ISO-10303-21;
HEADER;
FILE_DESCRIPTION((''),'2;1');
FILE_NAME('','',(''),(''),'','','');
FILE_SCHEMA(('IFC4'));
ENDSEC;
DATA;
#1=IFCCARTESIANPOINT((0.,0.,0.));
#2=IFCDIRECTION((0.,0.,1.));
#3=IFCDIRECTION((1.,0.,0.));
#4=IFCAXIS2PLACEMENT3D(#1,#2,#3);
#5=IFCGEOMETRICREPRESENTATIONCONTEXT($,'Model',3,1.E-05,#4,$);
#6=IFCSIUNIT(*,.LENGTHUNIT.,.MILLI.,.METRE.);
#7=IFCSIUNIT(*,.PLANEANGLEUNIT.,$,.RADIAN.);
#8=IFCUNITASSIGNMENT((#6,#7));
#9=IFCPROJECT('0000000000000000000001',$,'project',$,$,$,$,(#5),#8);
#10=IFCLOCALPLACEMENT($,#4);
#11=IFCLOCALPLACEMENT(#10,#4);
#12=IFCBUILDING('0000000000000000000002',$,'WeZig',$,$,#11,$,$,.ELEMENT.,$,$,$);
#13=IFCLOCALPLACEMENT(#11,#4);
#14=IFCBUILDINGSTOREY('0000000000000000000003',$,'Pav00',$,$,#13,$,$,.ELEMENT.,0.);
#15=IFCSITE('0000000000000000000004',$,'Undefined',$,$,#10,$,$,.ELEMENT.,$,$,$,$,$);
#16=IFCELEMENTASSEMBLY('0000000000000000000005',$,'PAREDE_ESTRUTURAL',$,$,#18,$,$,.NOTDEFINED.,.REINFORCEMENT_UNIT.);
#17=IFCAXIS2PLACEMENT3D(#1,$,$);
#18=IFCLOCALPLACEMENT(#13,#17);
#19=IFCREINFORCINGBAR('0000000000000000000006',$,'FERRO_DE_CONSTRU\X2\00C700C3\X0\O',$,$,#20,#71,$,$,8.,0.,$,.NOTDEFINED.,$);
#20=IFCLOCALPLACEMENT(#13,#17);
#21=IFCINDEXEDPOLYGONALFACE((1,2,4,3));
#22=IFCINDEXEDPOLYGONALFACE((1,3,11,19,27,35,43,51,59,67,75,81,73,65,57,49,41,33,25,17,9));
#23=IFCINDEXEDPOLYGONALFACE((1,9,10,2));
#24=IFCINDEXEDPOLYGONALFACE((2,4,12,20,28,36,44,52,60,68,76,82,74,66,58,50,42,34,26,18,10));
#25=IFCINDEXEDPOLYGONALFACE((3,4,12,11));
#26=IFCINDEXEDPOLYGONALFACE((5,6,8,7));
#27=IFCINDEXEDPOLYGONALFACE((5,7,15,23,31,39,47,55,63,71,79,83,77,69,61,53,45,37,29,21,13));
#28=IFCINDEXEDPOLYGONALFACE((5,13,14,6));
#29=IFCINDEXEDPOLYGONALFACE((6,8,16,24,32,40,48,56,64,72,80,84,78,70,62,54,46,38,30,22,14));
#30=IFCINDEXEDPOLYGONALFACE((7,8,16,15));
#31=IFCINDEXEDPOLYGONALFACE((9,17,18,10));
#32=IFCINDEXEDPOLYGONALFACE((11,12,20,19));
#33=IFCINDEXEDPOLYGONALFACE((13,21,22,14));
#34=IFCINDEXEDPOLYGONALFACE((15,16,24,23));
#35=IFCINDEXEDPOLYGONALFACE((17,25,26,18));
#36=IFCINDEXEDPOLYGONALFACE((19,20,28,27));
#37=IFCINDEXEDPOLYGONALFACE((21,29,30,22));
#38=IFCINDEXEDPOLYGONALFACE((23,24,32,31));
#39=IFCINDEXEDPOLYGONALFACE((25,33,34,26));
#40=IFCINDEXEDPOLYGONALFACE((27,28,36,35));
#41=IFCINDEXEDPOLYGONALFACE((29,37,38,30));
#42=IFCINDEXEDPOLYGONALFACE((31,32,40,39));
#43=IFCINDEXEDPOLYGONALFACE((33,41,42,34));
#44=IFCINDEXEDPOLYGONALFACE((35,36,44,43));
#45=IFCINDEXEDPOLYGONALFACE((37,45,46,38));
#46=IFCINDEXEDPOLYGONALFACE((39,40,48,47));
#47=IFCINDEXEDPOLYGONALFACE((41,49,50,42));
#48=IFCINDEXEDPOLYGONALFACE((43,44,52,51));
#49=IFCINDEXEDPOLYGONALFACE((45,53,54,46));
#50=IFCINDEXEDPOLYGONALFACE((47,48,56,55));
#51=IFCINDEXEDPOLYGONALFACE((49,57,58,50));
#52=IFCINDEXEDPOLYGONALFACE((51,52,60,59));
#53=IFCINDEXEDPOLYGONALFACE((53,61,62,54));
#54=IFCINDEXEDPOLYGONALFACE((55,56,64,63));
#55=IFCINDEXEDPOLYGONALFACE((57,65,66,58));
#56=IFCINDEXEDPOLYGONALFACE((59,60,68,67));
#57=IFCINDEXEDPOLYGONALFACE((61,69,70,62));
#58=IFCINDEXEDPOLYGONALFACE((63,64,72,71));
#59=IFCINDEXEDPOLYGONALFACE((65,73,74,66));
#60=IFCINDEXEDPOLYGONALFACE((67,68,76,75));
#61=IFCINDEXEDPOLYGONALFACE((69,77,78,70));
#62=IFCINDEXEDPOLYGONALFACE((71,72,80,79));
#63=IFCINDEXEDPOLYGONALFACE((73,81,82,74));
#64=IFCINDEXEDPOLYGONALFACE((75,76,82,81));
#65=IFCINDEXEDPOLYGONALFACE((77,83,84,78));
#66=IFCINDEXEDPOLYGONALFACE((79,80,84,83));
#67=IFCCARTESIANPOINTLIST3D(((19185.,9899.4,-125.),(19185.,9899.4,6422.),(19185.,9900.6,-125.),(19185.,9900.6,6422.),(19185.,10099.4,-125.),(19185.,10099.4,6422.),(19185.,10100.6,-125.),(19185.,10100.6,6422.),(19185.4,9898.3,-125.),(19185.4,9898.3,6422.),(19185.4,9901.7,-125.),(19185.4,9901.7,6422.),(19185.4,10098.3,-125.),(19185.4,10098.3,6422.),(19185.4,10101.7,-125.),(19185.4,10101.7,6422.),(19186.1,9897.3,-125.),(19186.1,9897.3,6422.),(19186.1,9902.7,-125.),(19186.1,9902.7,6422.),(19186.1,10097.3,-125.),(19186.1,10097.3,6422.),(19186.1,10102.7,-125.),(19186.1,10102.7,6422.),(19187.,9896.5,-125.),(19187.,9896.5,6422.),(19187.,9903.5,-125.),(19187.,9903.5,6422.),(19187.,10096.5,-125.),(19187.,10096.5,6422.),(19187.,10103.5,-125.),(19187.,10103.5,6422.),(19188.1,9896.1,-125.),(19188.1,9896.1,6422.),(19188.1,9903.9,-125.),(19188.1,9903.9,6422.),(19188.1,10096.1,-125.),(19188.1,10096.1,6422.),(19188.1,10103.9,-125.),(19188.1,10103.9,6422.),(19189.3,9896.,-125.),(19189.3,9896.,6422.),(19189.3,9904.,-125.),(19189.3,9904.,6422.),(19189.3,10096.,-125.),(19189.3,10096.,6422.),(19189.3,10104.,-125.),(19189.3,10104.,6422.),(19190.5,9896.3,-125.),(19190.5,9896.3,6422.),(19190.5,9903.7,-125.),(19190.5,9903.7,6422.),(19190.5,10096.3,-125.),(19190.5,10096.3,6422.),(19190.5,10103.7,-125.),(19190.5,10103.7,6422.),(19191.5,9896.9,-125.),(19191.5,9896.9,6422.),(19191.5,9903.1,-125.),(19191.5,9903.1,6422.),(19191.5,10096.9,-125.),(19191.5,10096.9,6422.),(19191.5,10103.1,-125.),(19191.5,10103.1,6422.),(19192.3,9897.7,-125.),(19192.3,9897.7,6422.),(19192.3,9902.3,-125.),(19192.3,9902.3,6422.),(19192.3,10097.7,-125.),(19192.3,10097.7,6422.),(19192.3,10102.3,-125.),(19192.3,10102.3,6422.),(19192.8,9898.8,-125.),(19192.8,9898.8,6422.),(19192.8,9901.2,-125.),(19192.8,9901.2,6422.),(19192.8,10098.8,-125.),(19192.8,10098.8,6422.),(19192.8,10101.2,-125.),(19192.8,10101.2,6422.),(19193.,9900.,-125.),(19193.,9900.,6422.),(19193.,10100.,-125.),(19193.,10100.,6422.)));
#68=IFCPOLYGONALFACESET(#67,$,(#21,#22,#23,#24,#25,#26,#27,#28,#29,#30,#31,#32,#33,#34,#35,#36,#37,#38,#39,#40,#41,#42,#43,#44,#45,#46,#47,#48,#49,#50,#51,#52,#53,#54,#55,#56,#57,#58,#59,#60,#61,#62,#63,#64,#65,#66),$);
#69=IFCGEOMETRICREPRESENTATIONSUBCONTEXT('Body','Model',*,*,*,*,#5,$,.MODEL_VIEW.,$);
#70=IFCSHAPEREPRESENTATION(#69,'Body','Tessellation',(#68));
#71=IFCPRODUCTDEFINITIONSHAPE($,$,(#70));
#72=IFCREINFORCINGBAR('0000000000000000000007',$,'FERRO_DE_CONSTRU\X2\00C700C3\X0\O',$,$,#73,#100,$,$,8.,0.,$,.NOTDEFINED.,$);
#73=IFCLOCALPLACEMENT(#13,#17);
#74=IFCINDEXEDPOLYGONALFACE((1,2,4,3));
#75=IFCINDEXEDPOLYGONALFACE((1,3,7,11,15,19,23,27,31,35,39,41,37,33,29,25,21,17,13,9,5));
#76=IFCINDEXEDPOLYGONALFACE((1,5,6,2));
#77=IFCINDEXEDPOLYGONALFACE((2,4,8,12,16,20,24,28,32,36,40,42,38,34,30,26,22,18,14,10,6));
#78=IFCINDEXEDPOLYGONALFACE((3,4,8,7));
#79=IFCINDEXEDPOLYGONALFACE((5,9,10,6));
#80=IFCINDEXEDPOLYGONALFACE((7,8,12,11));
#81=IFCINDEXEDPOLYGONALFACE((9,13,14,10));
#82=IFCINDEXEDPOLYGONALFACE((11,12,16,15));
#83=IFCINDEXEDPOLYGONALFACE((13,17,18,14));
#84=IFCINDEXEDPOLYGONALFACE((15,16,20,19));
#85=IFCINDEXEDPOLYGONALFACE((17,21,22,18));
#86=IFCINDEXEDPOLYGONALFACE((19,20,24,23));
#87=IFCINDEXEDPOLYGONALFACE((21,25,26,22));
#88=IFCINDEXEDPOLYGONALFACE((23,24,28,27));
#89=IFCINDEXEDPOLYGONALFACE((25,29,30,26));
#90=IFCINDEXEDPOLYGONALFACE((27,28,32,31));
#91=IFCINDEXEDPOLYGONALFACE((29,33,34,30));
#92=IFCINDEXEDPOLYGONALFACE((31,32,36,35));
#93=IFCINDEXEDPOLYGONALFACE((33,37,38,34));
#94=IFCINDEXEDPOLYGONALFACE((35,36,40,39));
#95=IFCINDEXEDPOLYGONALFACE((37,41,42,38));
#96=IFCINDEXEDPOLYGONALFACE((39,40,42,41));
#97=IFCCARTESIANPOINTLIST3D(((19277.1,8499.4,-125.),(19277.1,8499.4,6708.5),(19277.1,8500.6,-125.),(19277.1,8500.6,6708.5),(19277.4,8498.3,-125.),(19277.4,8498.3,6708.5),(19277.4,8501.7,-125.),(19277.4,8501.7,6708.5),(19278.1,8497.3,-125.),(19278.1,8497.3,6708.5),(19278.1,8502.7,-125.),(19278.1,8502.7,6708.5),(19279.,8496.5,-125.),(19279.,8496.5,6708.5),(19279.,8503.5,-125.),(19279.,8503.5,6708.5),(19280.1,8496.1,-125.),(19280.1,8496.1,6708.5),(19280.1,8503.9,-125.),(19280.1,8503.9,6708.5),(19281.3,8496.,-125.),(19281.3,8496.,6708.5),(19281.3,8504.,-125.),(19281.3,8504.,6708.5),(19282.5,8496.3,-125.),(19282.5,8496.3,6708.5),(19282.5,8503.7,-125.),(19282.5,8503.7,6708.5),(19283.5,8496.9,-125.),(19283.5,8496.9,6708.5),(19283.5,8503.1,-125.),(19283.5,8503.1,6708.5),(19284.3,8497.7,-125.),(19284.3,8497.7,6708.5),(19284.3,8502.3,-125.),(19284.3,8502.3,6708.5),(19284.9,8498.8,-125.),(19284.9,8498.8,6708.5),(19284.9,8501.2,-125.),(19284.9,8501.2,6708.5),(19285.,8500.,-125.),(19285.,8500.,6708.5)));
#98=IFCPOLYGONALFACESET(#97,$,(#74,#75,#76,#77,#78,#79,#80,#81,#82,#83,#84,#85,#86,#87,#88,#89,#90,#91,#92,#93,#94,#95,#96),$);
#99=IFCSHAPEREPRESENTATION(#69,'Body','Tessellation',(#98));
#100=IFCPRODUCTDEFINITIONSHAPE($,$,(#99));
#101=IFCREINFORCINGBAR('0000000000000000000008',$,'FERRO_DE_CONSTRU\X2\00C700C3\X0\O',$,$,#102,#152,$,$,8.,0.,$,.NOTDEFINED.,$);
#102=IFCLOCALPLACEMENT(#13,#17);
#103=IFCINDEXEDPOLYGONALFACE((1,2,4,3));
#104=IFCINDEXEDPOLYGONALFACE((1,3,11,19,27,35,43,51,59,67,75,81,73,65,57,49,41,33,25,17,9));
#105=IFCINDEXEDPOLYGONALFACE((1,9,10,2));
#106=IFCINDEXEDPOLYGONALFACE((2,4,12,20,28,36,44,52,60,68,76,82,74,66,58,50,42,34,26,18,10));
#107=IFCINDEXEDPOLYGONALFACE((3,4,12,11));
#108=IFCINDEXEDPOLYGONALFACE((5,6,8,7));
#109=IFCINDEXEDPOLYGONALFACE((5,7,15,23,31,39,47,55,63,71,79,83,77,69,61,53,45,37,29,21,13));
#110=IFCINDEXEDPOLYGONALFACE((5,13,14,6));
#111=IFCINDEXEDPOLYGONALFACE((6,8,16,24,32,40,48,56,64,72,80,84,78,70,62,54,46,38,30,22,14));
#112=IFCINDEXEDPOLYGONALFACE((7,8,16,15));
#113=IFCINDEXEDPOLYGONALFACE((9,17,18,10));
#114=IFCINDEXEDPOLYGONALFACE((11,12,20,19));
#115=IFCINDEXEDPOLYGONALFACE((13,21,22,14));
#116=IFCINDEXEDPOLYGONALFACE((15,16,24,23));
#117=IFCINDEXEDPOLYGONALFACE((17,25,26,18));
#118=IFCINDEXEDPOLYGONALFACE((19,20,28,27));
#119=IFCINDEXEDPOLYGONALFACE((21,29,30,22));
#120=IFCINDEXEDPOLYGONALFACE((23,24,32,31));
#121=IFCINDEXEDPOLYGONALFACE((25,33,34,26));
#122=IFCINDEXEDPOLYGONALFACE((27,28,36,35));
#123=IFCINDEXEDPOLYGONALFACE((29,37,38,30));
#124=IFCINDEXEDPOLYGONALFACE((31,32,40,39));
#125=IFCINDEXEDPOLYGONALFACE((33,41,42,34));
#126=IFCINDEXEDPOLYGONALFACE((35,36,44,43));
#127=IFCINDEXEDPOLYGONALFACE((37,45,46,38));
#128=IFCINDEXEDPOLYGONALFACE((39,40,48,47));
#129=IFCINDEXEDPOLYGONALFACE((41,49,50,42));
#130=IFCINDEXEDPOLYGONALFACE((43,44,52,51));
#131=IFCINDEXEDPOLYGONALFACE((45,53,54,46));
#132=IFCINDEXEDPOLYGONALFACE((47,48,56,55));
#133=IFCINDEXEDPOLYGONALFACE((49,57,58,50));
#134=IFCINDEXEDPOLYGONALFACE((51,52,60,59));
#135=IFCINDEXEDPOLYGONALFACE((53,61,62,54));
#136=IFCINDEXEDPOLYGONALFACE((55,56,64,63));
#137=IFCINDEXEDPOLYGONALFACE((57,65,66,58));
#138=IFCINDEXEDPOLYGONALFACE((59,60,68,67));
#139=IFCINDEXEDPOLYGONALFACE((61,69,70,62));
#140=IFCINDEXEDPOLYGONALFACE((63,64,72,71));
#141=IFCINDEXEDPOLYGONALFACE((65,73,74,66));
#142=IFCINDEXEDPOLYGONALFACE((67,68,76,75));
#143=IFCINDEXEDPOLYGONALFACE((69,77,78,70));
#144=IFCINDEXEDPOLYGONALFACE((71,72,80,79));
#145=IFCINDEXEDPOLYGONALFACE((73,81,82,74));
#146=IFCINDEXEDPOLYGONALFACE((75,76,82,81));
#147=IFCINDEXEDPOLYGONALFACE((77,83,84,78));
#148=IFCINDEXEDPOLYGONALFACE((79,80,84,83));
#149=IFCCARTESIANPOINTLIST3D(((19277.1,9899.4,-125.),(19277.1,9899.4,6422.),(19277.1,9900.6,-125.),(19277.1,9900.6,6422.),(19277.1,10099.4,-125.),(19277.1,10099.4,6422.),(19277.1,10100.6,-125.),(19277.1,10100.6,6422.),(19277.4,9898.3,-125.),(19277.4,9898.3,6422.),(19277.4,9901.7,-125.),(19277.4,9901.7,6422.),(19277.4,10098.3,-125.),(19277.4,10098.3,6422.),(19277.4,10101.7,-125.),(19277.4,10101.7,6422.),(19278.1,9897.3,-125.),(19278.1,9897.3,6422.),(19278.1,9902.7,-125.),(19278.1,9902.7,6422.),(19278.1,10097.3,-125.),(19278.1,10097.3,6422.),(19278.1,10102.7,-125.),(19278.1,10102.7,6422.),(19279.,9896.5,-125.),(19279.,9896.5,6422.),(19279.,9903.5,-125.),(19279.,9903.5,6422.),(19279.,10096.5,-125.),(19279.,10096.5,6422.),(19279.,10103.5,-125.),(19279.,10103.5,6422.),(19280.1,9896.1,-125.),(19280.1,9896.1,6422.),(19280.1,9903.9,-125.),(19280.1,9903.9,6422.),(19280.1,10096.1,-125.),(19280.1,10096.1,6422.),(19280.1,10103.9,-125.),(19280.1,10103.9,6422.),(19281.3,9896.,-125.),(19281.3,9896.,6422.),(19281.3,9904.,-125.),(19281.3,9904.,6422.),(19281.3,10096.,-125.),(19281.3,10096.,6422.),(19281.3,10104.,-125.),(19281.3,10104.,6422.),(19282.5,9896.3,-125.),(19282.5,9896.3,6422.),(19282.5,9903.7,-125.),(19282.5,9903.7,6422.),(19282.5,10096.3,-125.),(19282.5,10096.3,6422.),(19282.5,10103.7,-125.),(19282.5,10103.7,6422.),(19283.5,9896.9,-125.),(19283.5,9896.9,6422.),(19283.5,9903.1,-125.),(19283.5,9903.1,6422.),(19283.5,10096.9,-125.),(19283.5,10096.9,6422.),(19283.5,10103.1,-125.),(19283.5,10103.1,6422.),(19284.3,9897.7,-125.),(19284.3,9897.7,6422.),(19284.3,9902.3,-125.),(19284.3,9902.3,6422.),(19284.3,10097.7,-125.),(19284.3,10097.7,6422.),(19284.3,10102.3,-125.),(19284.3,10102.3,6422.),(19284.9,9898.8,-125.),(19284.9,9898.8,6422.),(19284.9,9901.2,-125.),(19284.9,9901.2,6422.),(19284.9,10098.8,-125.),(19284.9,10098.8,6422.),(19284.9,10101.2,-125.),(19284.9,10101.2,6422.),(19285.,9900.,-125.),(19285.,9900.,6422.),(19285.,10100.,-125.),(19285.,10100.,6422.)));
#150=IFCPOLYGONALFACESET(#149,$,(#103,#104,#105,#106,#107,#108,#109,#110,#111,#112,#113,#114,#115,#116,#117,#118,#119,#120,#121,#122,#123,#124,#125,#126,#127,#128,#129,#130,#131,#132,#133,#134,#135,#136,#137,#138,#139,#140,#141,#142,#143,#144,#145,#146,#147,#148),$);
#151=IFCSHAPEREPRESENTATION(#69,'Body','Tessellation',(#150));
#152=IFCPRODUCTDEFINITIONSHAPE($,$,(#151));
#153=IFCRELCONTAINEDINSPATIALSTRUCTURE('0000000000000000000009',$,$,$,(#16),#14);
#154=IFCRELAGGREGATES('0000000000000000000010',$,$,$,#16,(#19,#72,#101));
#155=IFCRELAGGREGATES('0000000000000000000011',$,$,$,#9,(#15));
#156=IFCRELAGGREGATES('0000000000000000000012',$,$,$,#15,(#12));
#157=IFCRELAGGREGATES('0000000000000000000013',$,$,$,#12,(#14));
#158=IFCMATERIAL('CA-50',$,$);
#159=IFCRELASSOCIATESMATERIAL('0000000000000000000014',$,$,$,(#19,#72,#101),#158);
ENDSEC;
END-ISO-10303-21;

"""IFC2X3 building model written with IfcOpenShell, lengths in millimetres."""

from ifc_helpers import new_model, entity, si_unit, frame, origin_with_axes, place, context, subcontext, project, spatial, source, transform, mapped, material, element, aggregate, save


model = new_model("IFC2X3")

# Units and contexts
model_context = context("Model", 3, precision=1e-05, world=origin_with_axes())
body_context = subcontext(model_context, "Body", "Model", "MODEL_VIEW")
ifc_project = project(units=[si_unit("LENGTHUNIT", "METRE", prefix="MILLI"), si_unit("PLANEANGLEUNIT", "RADIAN")], contexts=[model_context])

# Site, building, storey
site_placement = place(None, origin_with_axes())
site = spatial("IfcSite", under=ifc_project, at=site_placement, Name="Undefined", CompositionType="ELEMENT")
building_placement = place(site_placement, origin_with_axes())
building = spatial("IfcBuilding", under=site, at=building_placement, Name="WeZig", CompositionType="ELEMENT")
storey_placement = place(building_placement, origin_with_axes())
storey = spatial("IfcBuildingStorey", under=building, at=storey_placement, Name="Pav00", CompositionType="ELEMENT", Elevation=0.0)

# Element assembly
assembly_1_placement = place(storey_placement, origin_with_axes())
assembly_1 = element("IfcElementAssembly", 1, at=assembly_1_placement, inside=storey, Name="PAREDE_ESTRUTURAL", AssemblyPlace="NOTDEFINED", PredefinedType="REINFORCEMENT_UNIT")

# Reinforcing bars
ifc_material_1 = material(Name="CA-50")
shared_shape_1 = source(origin_with_axes(), body_context, "Body", "AdvancedSweptSolid", [
    entity("IfcSweptDiskSolid", entity("IfcTrimmedCurve", entity("IfcLine", entity("IfcCartesianPoint", [0.0, 0.0, 0.0]), entity("IfcVector", entity("IfcDirection", [1.0, 0.0, 0.0]), 1.0)), [entity("IfcParameterValue", 0.0)], [entity("IfcParameterValue", 6546.999619)], True, "PARAMETER"), 4.0, None, 0.0, 6547.0),
])
shared_shape_2 = source(origin_with_axes(), body_context, "Body", "AdvancedSweptSolid", [
    entity("IfcSweptDiskSolid", entity("IfcTrimmedCurve", entity("IfcLine", entity("IfcCartesianPoint", [0.0, 0.0, 0.0]), entity("IfcVector", entity("IfcDirection", [1.0, 0.0, 0.0]), 1.0)), [entity("IfcParameterValue", 0.0)], [entity("IfcParameterValue", 6546.999619)], True, "PARAMETER"), 4.0, None, 0.0, 6547.0),
])
reinforcing_bar_1_placement = place(assembly_1_placement, frame((19189.0, 9900.0, 6422.0), z_axis=(1.0, 0.0, 0.0), x_axis=(0.0, 0.0, -1.0)))
reinforcing_bar_1 = element("IfcReinforcingBar", 2, at=reinforcing_bar_1_placement, material=ifc_material_1, Name="FERRO_DE_CONSTRUÇÃO", BarRole="NOTDEFINED", CrossSectionArea=0.0, NominalDiameter=8.0, context=body_context, shape_type="MappedRepresentation", body=[
    mapped(shared_shape_1, transform((0.0, 0.0, 0.0))),
    mapped(shared_shape_2, transform((0.0, 200.0, 0.0))),
])
shared_shape_3 = source(origin_with_axes(), body_context, "Body", "AdvancedSweptSolid", [
    entity("IfcSweptDiskSolid", entity("IfcTrimmedCurve", entity("IfcLine", entity("IfcCartesianPoint", [0.0, 0.0, 0.0]), entity("IfcVector", entity("IfcDirection", [1.0, 0.0, 0.0]), 1.0)), [entity("IfcParameterValue", 0.0)], [entity("IfcParameterValue", 6833.500084)], True, "PARAMETER"), 4.0, None, 0.0, 6833.5),
])
reinforcing_bar_2_placement = place(assembly_1_placement, frame((19281.0, 8500.0, 6708.5), z_axis=(1.0, 0.0, 0.0), x_axis=(0.0, 0.0, -1.0)))
reinforcing_bar_2 = element("IfcReinforcingBar", 3, at=reinforcing_bar_2_placement, material=ifc_material_1, Name="FERRO_DE_CONSTRUÇÃO", BarRole="NOTDEFINED", CrossSectionArea=0.0, NominalDiameter=8.0, context=body_context, shape_type="MappedRepresentation", body=[
    mapped(shared_shape_3, transform((0.0, 0.0, 0.0))),
])
shared_shape_4 = source(origin_with_axes(), body_context, "Body", "AdvancedSweptSolid", [
    entity("IfcSweptDiskSolid", entity("IfcTrimmedCurve", entity("IfcLine", entity("IfcCartesianPoint", [0.0, 0.0, 0.0]), entity("IfcVector", entity("IfcDirection", [1.0, 0.0, 0.0]), 1.0)), [entity("IfcParameterValue", 0.0)], [entity("IfcParameterValue", 6546.999619)], True, "PARAMETER"), 4.0, None, 0.0, 6547.0),
])
shared_shape_5 = source(origin_with_axes(), body_context, "Body", "AdvancedSweptSolid", [
    entity("IfcSweptDiskSolid", entity("IfcTrimmedCurve", entity("IfcLine", entity("IfcCartesianPoint", [0.0, 0.0, 0.0]), entity("IfcVector", entity("IfcDirection", [1.0, 0.0, 0.0]), 1.0)), [entity("IfcParameterValue", 0.0)], [entity("IfcParameterValue", 6546.999619)], True, "PARAMETER"), 4.0, None, 0.0, 6547.0),
])
reinforcing_bar_3_placement = place(assembly_1_placement, frame((19281.0, 9900.0, 6422.0), z_axis=(1.0, 0.0, 0.0), x_axis=(0.0, 0.0, -1.0)))
reinforcing_bar_3 = element("IfcReinforcingBar", 4, at=reinforcing_bar_3_placement, material=ifc_material_1, Name="FERRO_DE_CONSTRUÇÃO", BarRole="NOTDEFINED", CrossSectionArea=0.0, NominalDiameter=8.0, context=body_context, shape_type="MappedRepresentation", body=[
    mapped(shared_shape_4, transform((0.0, 0.0, 0.0))),
    mapped(shared_shape_5, transform((0.0, 200.0, 0.0))),
])
aggregate(assembly_1, [reinforcing_bar_1, reinforcing_bar_2, reinforcing_bar_3])

save(model, "model.ifc")
